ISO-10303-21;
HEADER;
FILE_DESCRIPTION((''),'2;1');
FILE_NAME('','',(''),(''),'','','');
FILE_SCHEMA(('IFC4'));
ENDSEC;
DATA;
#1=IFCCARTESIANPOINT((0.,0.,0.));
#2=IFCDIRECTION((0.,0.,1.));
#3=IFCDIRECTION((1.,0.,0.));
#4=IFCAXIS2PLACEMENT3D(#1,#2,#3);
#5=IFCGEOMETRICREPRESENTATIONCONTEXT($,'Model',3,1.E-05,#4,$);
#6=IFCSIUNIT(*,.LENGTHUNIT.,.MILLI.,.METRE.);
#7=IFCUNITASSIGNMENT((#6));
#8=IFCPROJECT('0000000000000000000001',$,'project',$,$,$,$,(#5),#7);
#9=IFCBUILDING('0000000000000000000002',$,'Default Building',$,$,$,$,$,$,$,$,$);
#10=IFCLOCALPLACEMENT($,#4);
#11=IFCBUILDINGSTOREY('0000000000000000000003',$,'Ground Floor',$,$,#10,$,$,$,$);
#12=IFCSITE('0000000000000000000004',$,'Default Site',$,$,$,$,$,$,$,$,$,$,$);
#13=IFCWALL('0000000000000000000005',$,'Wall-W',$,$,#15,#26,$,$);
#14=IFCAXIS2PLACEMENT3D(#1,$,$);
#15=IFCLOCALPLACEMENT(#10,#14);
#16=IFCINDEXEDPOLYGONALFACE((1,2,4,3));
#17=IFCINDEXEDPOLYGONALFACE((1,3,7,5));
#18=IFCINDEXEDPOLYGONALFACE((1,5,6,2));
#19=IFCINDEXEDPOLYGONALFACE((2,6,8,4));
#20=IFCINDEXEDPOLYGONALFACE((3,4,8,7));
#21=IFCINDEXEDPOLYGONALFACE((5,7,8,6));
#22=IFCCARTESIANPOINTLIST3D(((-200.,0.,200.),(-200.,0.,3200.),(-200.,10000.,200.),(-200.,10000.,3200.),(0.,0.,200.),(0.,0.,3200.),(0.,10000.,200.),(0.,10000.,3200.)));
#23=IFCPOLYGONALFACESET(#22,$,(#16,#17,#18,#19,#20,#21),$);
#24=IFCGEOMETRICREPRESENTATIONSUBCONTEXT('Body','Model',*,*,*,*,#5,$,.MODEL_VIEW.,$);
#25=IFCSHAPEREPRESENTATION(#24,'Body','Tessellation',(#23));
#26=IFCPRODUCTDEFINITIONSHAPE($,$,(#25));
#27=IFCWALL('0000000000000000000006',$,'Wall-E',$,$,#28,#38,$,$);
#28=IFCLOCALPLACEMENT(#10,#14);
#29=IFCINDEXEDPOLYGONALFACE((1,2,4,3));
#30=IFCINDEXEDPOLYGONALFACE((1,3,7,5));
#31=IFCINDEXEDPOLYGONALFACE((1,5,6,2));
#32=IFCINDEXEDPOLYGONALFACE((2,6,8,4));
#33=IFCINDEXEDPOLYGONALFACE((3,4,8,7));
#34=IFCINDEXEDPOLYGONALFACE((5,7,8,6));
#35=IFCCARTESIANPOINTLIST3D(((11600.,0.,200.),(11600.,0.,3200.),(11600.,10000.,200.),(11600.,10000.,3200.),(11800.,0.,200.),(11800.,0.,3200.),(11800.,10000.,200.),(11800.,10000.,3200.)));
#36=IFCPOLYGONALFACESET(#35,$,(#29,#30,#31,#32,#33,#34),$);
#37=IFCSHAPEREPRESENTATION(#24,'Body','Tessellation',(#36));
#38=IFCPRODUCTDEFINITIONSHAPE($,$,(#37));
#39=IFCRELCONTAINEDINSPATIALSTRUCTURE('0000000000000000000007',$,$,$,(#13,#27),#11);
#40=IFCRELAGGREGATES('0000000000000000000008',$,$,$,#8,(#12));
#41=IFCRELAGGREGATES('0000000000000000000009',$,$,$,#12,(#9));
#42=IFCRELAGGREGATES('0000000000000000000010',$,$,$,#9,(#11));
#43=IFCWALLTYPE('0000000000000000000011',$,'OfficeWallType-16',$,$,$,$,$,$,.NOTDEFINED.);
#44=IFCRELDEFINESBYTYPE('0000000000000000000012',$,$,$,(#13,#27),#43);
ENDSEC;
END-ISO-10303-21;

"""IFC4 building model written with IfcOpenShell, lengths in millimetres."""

from ifc_helpers import new_model, si_unit, frame, origin_with_axes, place, context, subcontext, project, spatial, indexed_curve, outline, extrude, type_object, element, save


model = new_model("IFC4")

# Units and contexts
model_context = context("Model", 3, precision=1e-05, world=origin_with_axes())
body_context = subcontext(model_context, "Body", "Model", "MODEL_VIEW")
ifc_project = project(units=[si_unit("LENGTHUNIT", "METRE", prefix="MILLI")], contexts=[model_context])

# Site, building, storey
site = spatial("IfcSite", under=ifc_project, Name="Default Site")
building = spatial("IfcBuilding", under=site, Name="Default Building")
storey_placement = place(None, origin_with_axes())
storey = spatial("IfcBuildingStorey", under=building, at=storey_placement, Name="Ground Floor")

# Shared definitions
wall_type = type_object("IfcWallType", Name="OfficeWallType-16", PredefinedType="NOTDEFINED")

# Walls
wall_1_placement = place(storey_placement, frame((0.0, 0.0, 200.0), z_axis=(0.0, 0.0, 1.0), x_axis=(1.0, 0.0, 0.0)))
element("IfcWall", 1, at=wall_1_placement, inside=storey, type_object=wall_type, Name="Wall-W", context=body_context, shape_type="SweptSolid", body=[
    extrude(outline(indexed_curve([(0.0, 0.0), (0.0, 10000.0), (-200.0, 10000.0), (-200.0, 0.0), (0.0, 0.0)])), None, (0.0, 0.0, 1.0), 3000.0),
])
wall_2_placement = place(storey_placement, frame((0.0, 0.0, 200.0), z_axis=(0.0, 0.0, 1.0), x_axis=(1.0, 0.0, 0.0)))
element("IfcWall", 2, at=wall_2_placement, inside=storey, type_object=wall_type, Name="Wall-E", context=body_context, shape_type="SweptSolid", body=[
    extrude(outline(indexed_curve([(11800.0, 0.0), (11800.0, 10000.0), (11600.0, 10000.0), (11600.0, 0.0), (11800.0, 0.0)])), None, (0.0, 0.0, 1.0), 3000.0),
])

save(model, "model.ifc")
